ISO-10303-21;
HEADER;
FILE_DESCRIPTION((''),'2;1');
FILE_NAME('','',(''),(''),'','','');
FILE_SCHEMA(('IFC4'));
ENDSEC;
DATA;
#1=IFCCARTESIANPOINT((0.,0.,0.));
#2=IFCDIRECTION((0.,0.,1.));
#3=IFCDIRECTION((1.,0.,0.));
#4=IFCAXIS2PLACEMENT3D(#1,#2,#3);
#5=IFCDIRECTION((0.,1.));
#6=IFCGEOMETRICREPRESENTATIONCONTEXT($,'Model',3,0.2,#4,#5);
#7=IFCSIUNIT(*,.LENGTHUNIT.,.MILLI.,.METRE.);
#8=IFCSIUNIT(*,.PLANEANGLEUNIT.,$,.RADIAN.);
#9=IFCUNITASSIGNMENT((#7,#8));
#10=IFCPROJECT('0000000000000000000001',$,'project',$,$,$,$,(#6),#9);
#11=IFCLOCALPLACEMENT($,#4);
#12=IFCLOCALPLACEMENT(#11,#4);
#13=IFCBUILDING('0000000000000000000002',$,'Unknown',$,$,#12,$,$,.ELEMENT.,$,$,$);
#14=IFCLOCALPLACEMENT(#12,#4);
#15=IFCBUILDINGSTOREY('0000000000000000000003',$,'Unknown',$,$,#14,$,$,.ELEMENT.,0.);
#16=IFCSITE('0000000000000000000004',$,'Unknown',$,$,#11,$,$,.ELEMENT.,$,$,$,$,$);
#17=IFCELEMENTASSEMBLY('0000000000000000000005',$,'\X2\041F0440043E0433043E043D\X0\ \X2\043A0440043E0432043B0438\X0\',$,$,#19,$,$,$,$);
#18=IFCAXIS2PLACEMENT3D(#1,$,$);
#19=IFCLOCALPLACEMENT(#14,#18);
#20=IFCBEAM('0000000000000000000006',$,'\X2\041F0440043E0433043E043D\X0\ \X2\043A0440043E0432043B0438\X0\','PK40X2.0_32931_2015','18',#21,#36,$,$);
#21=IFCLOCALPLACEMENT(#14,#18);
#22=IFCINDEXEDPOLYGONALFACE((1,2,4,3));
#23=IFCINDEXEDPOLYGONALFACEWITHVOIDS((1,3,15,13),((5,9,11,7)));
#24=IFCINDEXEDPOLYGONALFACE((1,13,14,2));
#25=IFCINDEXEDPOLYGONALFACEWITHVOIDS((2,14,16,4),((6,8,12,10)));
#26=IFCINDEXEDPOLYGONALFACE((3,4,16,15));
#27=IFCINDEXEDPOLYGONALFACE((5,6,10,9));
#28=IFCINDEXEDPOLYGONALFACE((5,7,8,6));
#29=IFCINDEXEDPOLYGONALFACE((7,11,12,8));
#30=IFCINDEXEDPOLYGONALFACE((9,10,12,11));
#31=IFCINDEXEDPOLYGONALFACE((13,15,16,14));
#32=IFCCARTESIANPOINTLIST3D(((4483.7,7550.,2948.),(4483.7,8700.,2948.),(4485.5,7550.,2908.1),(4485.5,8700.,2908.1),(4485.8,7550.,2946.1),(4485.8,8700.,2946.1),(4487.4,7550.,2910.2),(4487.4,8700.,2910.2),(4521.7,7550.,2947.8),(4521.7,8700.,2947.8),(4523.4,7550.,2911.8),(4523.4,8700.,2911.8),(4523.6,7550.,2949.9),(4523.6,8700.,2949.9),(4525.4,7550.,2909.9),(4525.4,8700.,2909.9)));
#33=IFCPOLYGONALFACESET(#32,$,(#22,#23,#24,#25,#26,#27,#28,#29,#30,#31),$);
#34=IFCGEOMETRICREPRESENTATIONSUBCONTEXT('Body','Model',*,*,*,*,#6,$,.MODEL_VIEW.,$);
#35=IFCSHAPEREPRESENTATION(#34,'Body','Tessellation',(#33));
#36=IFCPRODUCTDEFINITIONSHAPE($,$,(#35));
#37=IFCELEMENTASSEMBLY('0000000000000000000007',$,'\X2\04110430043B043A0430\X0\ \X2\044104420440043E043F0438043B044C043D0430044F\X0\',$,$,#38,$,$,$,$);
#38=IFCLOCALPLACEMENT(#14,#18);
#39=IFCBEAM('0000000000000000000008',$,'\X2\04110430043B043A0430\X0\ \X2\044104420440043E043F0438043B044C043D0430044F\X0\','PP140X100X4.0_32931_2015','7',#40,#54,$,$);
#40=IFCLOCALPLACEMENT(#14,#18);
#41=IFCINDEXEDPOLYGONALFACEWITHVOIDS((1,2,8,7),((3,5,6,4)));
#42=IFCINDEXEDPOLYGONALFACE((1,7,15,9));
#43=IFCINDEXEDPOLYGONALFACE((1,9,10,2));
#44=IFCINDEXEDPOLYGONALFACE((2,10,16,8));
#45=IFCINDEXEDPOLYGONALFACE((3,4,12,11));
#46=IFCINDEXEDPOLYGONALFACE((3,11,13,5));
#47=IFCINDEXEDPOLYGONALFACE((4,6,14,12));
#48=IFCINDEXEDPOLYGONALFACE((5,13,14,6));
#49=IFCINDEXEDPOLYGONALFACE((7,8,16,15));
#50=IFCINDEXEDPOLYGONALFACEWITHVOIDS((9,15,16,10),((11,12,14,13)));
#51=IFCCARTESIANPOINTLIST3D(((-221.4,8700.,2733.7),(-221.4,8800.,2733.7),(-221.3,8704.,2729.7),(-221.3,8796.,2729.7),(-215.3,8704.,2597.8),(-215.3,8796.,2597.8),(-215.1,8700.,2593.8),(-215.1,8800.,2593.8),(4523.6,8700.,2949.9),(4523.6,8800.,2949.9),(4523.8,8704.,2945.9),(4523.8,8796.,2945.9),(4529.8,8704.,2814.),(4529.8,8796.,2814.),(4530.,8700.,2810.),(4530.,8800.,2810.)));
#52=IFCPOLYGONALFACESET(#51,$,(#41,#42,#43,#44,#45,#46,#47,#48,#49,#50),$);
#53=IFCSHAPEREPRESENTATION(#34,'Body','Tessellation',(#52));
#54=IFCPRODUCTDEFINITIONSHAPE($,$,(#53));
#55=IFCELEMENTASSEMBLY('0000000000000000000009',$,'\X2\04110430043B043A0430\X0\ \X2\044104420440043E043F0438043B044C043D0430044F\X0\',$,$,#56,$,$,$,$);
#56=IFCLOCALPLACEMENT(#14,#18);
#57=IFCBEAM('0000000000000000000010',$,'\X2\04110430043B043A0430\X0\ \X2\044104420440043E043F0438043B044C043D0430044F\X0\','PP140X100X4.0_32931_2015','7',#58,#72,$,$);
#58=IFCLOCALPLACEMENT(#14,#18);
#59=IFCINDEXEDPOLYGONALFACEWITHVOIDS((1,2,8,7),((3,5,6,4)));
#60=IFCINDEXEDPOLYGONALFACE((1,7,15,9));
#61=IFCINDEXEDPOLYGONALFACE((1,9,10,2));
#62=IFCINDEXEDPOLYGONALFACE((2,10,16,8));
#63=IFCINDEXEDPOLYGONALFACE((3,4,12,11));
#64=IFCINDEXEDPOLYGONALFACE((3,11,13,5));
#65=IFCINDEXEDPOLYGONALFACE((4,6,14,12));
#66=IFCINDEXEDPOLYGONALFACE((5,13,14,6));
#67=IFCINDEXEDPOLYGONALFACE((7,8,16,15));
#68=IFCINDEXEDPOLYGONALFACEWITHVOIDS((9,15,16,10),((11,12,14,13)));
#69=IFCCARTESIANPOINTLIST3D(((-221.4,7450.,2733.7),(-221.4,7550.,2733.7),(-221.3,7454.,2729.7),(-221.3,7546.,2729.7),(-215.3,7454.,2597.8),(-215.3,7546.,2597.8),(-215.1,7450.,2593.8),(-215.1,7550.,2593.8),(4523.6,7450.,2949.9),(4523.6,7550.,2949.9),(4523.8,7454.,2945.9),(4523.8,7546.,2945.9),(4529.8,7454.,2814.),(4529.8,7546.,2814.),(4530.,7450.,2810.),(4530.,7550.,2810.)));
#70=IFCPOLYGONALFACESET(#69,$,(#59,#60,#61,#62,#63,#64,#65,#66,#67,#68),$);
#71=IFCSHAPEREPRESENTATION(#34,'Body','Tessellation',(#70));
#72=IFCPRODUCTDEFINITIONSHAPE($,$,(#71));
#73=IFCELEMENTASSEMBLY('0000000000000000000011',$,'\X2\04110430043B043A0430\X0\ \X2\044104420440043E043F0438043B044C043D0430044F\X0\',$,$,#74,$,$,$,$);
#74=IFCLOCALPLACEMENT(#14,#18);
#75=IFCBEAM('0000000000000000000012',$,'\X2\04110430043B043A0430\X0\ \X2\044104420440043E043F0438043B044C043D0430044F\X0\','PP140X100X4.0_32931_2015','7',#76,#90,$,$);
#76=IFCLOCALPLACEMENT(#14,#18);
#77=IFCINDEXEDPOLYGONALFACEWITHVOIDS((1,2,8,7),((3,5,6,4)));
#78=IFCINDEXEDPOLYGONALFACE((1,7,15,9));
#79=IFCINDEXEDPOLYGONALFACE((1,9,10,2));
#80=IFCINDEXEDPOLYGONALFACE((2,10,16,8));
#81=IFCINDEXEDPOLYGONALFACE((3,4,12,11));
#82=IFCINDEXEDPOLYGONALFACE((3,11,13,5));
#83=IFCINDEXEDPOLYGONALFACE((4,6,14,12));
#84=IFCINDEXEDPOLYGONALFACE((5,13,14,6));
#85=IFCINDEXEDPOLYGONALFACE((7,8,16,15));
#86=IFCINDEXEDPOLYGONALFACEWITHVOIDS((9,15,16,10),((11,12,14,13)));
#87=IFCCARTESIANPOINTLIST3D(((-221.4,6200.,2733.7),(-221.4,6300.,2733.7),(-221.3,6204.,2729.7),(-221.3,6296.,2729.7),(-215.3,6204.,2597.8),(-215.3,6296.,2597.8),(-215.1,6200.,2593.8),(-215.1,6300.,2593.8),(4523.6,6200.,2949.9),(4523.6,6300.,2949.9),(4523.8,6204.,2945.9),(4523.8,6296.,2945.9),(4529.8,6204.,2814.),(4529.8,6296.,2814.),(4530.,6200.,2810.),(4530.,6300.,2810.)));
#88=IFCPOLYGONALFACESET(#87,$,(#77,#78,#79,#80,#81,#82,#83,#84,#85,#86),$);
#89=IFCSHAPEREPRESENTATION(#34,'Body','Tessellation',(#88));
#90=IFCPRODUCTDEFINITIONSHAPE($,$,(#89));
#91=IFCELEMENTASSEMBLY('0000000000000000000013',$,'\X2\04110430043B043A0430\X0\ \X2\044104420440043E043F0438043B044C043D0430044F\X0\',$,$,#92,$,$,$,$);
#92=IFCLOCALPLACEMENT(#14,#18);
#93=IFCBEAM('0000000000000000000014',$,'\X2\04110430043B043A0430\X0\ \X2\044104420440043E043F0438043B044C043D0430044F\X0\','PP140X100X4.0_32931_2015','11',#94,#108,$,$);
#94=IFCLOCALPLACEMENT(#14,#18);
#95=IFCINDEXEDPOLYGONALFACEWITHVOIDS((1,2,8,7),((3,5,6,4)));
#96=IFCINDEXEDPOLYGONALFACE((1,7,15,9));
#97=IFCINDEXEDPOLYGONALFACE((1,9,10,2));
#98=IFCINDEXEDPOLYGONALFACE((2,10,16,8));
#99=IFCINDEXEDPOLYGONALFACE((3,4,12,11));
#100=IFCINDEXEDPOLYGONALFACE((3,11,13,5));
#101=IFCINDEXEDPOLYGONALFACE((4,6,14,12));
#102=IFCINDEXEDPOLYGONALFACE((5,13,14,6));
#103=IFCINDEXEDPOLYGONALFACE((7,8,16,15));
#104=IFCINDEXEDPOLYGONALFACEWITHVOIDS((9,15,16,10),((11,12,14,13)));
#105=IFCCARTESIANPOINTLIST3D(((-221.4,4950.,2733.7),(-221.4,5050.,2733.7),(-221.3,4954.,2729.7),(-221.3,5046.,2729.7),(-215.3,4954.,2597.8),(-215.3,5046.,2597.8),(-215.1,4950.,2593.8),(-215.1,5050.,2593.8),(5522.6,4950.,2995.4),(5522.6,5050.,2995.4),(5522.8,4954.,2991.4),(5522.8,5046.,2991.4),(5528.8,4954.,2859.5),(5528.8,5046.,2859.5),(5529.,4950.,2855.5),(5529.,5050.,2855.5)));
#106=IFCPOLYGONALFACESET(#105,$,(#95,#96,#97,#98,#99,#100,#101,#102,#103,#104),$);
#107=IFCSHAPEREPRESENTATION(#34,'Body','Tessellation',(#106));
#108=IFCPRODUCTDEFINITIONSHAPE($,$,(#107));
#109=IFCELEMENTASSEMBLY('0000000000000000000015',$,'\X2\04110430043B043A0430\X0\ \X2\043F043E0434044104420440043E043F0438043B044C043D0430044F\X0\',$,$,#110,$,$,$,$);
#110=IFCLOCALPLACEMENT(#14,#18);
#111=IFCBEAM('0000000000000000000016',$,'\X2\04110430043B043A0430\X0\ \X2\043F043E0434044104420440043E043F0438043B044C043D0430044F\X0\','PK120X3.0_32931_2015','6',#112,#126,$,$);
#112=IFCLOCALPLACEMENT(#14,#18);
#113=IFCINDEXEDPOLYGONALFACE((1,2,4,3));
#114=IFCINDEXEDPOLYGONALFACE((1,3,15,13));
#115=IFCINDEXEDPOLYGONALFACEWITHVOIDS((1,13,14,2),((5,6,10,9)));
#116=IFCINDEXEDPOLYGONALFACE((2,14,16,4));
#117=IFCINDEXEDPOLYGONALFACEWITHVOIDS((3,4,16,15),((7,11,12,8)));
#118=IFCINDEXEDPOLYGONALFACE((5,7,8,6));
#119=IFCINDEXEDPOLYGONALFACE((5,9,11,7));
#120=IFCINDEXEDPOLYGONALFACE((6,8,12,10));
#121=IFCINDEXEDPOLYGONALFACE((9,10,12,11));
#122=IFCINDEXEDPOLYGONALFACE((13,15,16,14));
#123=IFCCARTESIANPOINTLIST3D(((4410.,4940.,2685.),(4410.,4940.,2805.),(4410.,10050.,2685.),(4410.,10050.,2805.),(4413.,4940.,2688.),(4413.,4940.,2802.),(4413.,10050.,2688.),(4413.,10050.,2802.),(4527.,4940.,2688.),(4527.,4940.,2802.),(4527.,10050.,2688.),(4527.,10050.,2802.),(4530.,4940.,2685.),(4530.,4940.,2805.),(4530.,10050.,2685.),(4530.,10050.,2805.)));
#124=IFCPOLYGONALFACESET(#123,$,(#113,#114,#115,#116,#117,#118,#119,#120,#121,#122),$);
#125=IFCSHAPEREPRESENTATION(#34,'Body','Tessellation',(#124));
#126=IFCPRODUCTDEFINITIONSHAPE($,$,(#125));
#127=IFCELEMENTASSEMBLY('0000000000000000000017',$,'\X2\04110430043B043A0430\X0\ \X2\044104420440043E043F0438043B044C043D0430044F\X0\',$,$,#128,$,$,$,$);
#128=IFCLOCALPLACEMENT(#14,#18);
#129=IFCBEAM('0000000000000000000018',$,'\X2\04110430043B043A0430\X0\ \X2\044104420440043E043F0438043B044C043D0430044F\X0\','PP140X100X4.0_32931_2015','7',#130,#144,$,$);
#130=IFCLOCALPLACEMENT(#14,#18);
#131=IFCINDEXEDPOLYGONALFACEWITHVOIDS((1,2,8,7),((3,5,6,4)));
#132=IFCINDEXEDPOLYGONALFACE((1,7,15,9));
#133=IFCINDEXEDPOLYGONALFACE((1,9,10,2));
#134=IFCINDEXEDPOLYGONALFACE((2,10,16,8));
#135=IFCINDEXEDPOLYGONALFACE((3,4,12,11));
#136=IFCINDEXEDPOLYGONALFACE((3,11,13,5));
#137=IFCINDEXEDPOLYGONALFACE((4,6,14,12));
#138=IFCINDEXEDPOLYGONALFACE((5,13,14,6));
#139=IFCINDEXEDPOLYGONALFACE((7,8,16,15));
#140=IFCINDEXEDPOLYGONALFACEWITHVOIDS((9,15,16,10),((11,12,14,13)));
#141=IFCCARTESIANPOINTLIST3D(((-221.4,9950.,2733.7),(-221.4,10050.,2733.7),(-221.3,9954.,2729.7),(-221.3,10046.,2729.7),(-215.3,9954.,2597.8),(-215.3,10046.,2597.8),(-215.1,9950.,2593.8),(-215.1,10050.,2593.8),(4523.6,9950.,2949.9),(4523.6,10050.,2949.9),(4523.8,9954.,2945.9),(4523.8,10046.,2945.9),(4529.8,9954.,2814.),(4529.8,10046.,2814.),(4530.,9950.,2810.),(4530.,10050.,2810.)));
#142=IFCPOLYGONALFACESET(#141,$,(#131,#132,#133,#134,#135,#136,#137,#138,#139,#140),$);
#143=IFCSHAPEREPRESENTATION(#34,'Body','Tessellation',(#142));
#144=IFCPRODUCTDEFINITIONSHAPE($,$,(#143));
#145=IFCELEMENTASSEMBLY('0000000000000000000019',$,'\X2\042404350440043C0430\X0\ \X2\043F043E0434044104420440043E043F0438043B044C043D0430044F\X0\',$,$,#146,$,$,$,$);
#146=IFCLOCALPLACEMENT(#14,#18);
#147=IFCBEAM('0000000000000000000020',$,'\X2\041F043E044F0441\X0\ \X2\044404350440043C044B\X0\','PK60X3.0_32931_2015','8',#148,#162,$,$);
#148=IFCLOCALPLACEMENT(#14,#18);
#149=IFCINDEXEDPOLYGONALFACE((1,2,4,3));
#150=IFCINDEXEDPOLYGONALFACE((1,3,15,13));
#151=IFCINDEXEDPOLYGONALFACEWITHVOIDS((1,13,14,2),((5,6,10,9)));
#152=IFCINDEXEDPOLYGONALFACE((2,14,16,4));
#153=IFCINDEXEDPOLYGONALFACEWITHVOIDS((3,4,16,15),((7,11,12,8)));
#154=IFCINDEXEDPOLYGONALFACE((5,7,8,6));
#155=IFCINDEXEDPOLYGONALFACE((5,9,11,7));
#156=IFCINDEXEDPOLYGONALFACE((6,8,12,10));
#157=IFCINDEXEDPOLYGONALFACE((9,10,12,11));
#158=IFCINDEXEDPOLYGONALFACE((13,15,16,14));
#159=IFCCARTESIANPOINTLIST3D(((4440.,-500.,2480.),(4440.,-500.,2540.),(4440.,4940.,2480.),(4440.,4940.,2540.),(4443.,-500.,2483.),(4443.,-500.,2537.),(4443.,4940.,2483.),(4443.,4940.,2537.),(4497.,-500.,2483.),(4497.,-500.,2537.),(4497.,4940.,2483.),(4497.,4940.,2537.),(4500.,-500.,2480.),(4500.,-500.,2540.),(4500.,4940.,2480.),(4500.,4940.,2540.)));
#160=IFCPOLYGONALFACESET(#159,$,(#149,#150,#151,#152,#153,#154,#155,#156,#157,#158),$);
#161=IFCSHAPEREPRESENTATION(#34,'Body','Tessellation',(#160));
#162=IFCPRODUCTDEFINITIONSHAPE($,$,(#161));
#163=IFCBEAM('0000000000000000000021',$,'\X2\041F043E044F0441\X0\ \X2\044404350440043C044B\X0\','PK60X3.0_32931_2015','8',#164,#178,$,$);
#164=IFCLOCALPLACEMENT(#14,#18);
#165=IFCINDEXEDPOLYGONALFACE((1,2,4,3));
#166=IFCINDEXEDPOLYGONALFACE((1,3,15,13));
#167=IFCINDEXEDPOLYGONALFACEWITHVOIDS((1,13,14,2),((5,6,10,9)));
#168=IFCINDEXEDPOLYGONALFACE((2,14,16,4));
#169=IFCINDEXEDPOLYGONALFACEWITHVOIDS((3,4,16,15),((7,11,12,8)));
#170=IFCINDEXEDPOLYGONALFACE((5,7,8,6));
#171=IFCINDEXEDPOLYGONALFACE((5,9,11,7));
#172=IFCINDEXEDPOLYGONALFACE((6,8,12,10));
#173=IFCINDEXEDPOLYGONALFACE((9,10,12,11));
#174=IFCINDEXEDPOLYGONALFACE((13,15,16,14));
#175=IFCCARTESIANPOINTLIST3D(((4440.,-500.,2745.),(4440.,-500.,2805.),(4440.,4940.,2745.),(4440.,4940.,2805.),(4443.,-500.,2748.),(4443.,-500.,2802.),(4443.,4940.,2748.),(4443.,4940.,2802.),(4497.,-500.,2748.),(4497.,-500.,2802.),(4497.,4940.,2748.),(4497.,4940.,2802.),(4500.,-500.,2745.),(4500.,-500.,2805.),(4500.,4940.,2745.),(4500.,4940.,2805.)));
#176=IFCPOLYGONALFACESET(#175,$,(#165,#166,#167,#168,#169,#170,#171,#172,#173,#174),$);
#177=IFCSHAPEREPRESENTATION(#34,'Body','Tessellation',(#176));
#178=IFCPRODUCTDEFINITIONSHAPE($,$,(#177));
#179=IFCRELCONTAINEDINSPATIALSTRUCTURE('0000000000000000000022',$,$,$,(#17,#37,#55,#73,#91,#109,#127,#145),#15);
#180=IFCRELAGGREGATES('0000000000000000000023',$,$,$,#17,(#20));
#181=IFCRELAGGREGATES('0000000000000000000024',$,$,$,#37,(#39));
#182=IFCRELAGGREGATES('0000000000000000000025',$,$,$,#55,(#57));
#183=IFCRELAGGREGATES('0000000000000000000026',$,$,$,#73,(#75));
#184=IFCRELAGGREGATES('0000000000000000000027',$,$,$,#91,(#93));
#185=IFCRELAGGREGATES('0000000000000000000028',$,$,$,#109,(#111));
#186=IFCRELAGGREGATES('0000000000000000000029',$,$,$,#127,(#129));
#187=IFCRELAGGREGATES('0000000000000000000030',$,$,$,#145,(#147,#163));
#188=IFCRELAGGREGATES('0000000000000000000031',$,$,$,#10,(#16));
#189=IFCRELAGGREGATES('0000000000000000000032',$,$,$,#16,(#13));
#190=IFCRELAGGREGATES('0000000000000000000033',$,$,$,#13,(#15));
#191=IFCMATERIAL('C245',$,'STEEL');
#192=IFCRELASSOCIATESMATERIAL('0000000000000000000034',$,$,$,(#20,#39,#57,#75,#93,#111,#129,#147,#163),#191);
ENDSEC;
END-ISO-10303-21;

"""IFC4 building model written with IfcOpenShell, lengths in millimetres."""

from ifc_helpers import new_model, si_unit, direction, frame, origin_with_axes, place, context, subcontext, project, spatial, line, indexed_curve, outline, extrude, material, element, aggregate, save


model = new_model("IFC4")

# Units and contexts
model_context = context("Model", 3, precision=0.2, world=origin_with_axes(), true_north=direction((0.0, 1.0)))
body_context = subcontext(model_context, "Body", "Model", "MODEL_VIEW")
ifc_project = project(units=[si_unit("LENGTHUNIT", "METRE", prefix="MILLI"), si_unit("PLANEANGLEUNIT", "RADIAN")], contexts=[model_context])

# Site, building, storey
site_placement = place(None, origin_with_axes())
site = spatial("IfcSite", under=ifc_project, at=site_placement, Name="Unknown", CompositionType="ELEMENT")
building_placement = place(site_placement, origin_with_axes())
building = spatial("IfcBuilding", under=site, at=building_placement, Name="Unknown", CompositionType="ELEMENT")
storey_placement = place(building_placement, origin_with_axes())
storey = spatial("IfcBuildingStorey", under=building, at=storey_placement, Name="Unknown", CompositionType="ELEMENT", Elevation=0.0)

# Shared definitions
ifc_material_1 = material(Name="C245", Category="STEEL")

# Element assemblies, beams
assembly_1_placement = place(storey_placement, frame((4504.6, 8700.0, 2929.0), z_axis=(-0.998964, 0.0, -0.045508), x_axis=(0.0, -1.0, 0.0)))
assembly_1 = element("IfcElementAssembly", 1, at=assembly_1_placement, inside=storey, Name="Прогон кровли")
beam_1_placement = place(assembly_1_placement, origin_with_axes())
beam_1 = element("IfcBeam", 2, at=beam_1_placement, material=ifc_material_1, Name="Прогон кровли", Description="PK40X2.0_32931_2015", ObjectType="18", context=body_context, shape_type="SolidModel", body=[
    extrude(outline(indexed_curve([(-20.0, -20.0), (20.0, -20.0), (20.0, 20.0), (-20.0, 20.0)], segments=[line(1, 2, 3, 4, 1)]), holes=[indexed_curve([(-18.0, -18.0), (-18.0, 18.0), (18.0, 18.0), (18.0, -18.0)], segments=[line(1, 2, 3, 4, 1)])]), frame((0.0, 0.0, 0.0), z_axis=(-1.0, 0.0, 0.0), x_axis=(0.0, 0.0, 1.0)), (0.0, 0.0, -1.0), 1150.0),
])
aggregate(assembly_1, [beam_1])
assembly_2_placement = place(storey_placement, frame((4526.8, 8750.0, 2879.9), z_axis=(0.0, 1.0, 0.0), x_axis=(-0.998964, 0.0, -0.045508)))
assembly_2 = element("IfcElementAssembly", 3, at=assembly_2_placement, inside=storey, Name="Балка стропильная")
beam_2_placement = place(assembly_2_placement, origin_with_axes())
beam_2 = element("IfcBeam", 4, at=beam_2_placement, material=ifc_material_1, Name="Балка стропильная", Description="PP140X100X4.0_32931_2015", ObjectType="7", context=body_context, shape_type="SolidModel", body=[
    extrude(outline(indexed_curve([(-50.0, -70.0), (50.0, -70.0), (50.0, 70.0), (-50.0, 70.0)], segments=[line(1, 2, 3, 4, 1)]), holes=[indexed_curve([(-46.0, -66.0), (-46.0, 66.0), (46.0, 66.0), (46.0, -66.0)], segments=[line(1, 2, 3, 4, 1)])]), frame((0.0, 0.0, 0.0), z_axis=(-1.0, 0.0, 0.0), x_axis=(0.0, 0.0, 1.0)), (0.0, 0.0, -1.0), 4750.0),
])
aggregate(assembly_2, [beam_2])
assembly_3_placement = place(storey_placement, frame((4526.8, 7500.0, 2879.9), z_axis=(0.0, 1.0, 0.0), x_axis=(-0.998964, 0.0, -0.045508)))
assembly_3 = element("IfcElementAssembly", 5, at=assembly_3_placement, inside=storey, Name="Балка стропильная")
beam_3_placement = place(assembly_3_placement, origin_with_axes())
beam_3 = element("IfcBeam", 6, at=beam_3_placement, material=ifc_material_1, Name="Балка стропильная", Description="PP140X100X4.0_32931_2015", ObjectType="7", context=body_context, shape_type="SolidModel", body=[
    extrude(outline(indexed_curve([(-50.0, -70.0), (50.0, -70.0), (50.0, 70.0), (-50.0, 70.0)], segments=[line(1, 2, 3, 4, 1)]), holes=[indexed_curve([(-46.0, -66.0), (-46.0, 66.0), (46.0, 66.0), (46.0, -66.0)], segments=[line(1, 2, 3, 4, 1)])]), frame((0.0, 0.0, 0.0), z_axis=(-1.0, 0.0, 0.0), x_axis=(0.0, 0.0, 1.0)), (0.0, 0.0, -1.0), 4750.0),
])
aggregate(assembly_3, [beam_3])
assembly_4_placement = place(storey_placement, frame((4526.8, 6250.0, 2879.9), z_axis=(0.0, 1.0, 0.0), x_axis=(-0.998964, 0.0, -0.045508)))
assembly_4 = element("IfcElementAssembly", 7, at=assembly_4_placement, inside=storey, Name="Балка стропильная")
beam_4_placement = place(assembly_4_placement, origin_with_axes())
beam_4 = element("IfcBeam", 8, at=beam_4_placement, material=ifc_material_1, Name="Балка стропильная", Description="PP140X100X4.0_32931_2015", ObjectType="7", context=body_context, shape_type="SolidModel", body=[
    extrude(outline(indexed_curve([(-50.0, -70.0), (50.0, -70.0), (50.0, 70.0), (-50.0, 70.0)], segments=[line(1, 2, 3, 4, 1)]), holes=[indexed_curve([(-46.0, -66.0), (-46.0, 66.0), (46.0, 66.0), (46.0, -66.0)], segments=[line(1, 2, 3, 4, 1)])]), frame((0.0, 0.0, 0.0), z_axis=(-1.0, 0.0, 0.0), x_axis=(0.0, 0.0, 1.0)), (0.0, 0.0, -1.0), 4750.0),
])
aggregate(assembly_4, [beam_4])
assembly_5_placement = place(storey_placement, frame((5525.8, 5000.0, 2925.4), z_axis=(0.0, 1.0, 0.0), x_axis=(-0.998964, 0.0, -0.045508)))
assembly_5 = element("IfcElementAssembly", 9, at=assembly_5_placement, inside=storey, Name="Балка стропильная")
beam_5_placement = place(assembly_5_placement, origin_with_axes())
beam_5 = element("IfcBeam", 10, at=beam_5_placement, material=ifc_material_1, Name="Балка стропильная", Description="PP140X100X4.0_32931_2015", ObjectType="11", context=body_context, shape_type="SolidModel", body=[
    extrude(outline(indexed_curve([(-50.0, -70.0), (50.0, -70.0), (50.0, 70.0), (-50.0, 70.0)], segments=[line(1, 2, 3, 4, 1)]), holes=[indexed_curve([(-46.0, -66.0), (-46.0, 66.0), (46.0, 66.0), (46.0, -66.0)], segments=[line(1, 2, 3, 4, 1)])]), frame((0.0, 0.0, 0.0), z_axis=(-1.0, 0.0, 0.0), x_axis=(0.0, 0.0, 1.0)), (0.0, 0.0, -1.0), 5750.0),
])
aggregate(assembly_5, [beam_5])
assembly_6_placement = place(storey_placement, frame((4470.0, 10050.0, 2745.0), z_axis=(-1.0, 0.0, 0.0), x_axis=(0.0, -1.0, 0.0)))
assembly_6 = element("IfcElementAssembly", 11, at=assembly_6_placement, inside=storey, Name="Балка подстропильная")
beam_6_placement = place(assembly_6_placement, origin_with_axes())
beam_6 = element("IfcBeam", 12, at=beam_6_placement, material=ifc_material_1, Name="Балка подстропильная", Description="PK120X3.0_32931_2015", ObjectType="6", context=body_context, shape_type="SolidModel", body=[
    extrude(outline(indexed_curve([(-60.0, -60.0), (60.0, -60.0), (60.0, 60.0), (-60.0, 60.0)], segments=[line(1, 2, 3, 4, 1)]), holes=[indexed_curve([(-57.0, -57.0), (-57.0, 57.0), (57.0, 57.0), (57.0, -57.0)], segments=[line(1, 2, 3, 4, 1)])]), frame((0.0, 0.0, 0.0), z_axis=(-1.0, 0.0, 0.0), x_axis=(0.0, 0.0, 1.0)), (0.0, 0.0, -1.0), 5110.0),
])
aggregate(assembly_6, [beam_6])
assembly_7_placement = place(storey_placement, frame((4526.8, 10000.0, 2879.9), z_axis=(0.0, 1.0, 0.0), x_axis=(-0.998964, 0.0, -0.045508)))
assembly_7 = element("IfcElementAssembly", 13, at=assembly_7_placement, inside=storey, Name="Балка стропильная")
beam_7_placement = place(assembly_7_placement, origin_with_axes())
beam_7 = element("IfcBeam", 14, at=beam_7_placement, material=ifc_material_1, Name="Балка стропильная", Description="PP140X100X4.0_32931_2015", ObjectType="7", context=body_context, shape_type="SolidModel", body=[
    extrude(outline(indexed_curve([(-50.0, -70.0), (50.0, -70.0), (50.0, 70.0), (-50.0, 70.0)], segments=[line(1, 2, 3, 4, 1)]), holes=[indexed_curve([(-46.0, -66.0), (-46.0, 66.0), (46.0, 66.0), (46.0, -66.0)], segments=[line(1, 2, 3, 4, 1)])]), frame((0.0, 0.0, 0.0), z_axis=(-1.0, 0.0, 0.0), x_axis=(0.0, 0.0, 1.0)), (0.0, 0.0, -1.0), 4750.0),
])
aggregate(assembly_7, [beam_7])

# Element assembly, beams
assembly_8_placement = place(storey_placement, frame((4470.0, 4940.0, 2775.0), z_axis=(-1.0, 0.0, 0.0), x_axis=(0.0, -1.0, 0.0)))
assembly_8 = element("IfcElementAssembly", 15, at=assembly_8_placement, inside=storey, Name="Ферма подстропильная")
beam_8_placement = place(assembly_8_placement, frame((0.0, -265.0, 0.0), z_axis=(0.0, 0.0, 1.0), x_axis=(1.0, 0.0, 0.0)))
beam_8 = element("IfcBeam", 16, at=beam_8_placement, material=ifc_material_1, Name="Пояс фермы", Description="PK60X3.0_32931_2015", ObjectType="8", context=body_context, shape_type="SolidModel", body=[
    extrude(outline(indexed_curve([(-30.0, -30.0), (30.0, -30.0), (30.0, 30.0), (-30.0, 30.0)], segments=[line(1, 2, 3, 4, 1)]), holes=[indexed_curve([(-27.0, -27.0), (-27.0, 27.0), (27.0, 27.0), (27.0, -27.0)], segments=[line(1, 2, 3, 4, 1)])]), frame((0.0, 0.0, 0.0), z_axis=(-1.0, 0.0, 0.0), x_axis=(0.0, 0.0, 1.0)), (0.0, 0.0, -1.0), 5440.0),
])
beam_9_placement = place(assembly_8_placement, origin_with_axes())
beam_9 = element("IfcBeam", 17, at=beam_9_placement, material=ifc_material_1, Name="Пояс фермы", Description="PK60X3.0_32931_2015", ObjectType="8", context=body_context, shape_type="SolidModel", body=[
    extrude(outline(indexed_curve([(-30.0, -30.0), (30.0, -30.0), (30.0, 30.0), (-30.0, 30.0)], segments=[line(1, 2, 3, 4, 1)]), holes=[indexed_curve([(-27.0, -27.0), (-27.0, 27.0), (27.0, 27.0), (27.0, -27.0)], segments=[line(1, 2, 3, 4, 1)])]), frame((0.0, 0.0, 0.0), z_axis=(-1.0, 0.0, 0.0), x_axis=(0.0, 0.0, 1.0)), (0.0, 0.0, -1.0), 5440.0),
])
aggregate(assembly_8, [beam_8, beam_9])

save(model, "model.ifc")
